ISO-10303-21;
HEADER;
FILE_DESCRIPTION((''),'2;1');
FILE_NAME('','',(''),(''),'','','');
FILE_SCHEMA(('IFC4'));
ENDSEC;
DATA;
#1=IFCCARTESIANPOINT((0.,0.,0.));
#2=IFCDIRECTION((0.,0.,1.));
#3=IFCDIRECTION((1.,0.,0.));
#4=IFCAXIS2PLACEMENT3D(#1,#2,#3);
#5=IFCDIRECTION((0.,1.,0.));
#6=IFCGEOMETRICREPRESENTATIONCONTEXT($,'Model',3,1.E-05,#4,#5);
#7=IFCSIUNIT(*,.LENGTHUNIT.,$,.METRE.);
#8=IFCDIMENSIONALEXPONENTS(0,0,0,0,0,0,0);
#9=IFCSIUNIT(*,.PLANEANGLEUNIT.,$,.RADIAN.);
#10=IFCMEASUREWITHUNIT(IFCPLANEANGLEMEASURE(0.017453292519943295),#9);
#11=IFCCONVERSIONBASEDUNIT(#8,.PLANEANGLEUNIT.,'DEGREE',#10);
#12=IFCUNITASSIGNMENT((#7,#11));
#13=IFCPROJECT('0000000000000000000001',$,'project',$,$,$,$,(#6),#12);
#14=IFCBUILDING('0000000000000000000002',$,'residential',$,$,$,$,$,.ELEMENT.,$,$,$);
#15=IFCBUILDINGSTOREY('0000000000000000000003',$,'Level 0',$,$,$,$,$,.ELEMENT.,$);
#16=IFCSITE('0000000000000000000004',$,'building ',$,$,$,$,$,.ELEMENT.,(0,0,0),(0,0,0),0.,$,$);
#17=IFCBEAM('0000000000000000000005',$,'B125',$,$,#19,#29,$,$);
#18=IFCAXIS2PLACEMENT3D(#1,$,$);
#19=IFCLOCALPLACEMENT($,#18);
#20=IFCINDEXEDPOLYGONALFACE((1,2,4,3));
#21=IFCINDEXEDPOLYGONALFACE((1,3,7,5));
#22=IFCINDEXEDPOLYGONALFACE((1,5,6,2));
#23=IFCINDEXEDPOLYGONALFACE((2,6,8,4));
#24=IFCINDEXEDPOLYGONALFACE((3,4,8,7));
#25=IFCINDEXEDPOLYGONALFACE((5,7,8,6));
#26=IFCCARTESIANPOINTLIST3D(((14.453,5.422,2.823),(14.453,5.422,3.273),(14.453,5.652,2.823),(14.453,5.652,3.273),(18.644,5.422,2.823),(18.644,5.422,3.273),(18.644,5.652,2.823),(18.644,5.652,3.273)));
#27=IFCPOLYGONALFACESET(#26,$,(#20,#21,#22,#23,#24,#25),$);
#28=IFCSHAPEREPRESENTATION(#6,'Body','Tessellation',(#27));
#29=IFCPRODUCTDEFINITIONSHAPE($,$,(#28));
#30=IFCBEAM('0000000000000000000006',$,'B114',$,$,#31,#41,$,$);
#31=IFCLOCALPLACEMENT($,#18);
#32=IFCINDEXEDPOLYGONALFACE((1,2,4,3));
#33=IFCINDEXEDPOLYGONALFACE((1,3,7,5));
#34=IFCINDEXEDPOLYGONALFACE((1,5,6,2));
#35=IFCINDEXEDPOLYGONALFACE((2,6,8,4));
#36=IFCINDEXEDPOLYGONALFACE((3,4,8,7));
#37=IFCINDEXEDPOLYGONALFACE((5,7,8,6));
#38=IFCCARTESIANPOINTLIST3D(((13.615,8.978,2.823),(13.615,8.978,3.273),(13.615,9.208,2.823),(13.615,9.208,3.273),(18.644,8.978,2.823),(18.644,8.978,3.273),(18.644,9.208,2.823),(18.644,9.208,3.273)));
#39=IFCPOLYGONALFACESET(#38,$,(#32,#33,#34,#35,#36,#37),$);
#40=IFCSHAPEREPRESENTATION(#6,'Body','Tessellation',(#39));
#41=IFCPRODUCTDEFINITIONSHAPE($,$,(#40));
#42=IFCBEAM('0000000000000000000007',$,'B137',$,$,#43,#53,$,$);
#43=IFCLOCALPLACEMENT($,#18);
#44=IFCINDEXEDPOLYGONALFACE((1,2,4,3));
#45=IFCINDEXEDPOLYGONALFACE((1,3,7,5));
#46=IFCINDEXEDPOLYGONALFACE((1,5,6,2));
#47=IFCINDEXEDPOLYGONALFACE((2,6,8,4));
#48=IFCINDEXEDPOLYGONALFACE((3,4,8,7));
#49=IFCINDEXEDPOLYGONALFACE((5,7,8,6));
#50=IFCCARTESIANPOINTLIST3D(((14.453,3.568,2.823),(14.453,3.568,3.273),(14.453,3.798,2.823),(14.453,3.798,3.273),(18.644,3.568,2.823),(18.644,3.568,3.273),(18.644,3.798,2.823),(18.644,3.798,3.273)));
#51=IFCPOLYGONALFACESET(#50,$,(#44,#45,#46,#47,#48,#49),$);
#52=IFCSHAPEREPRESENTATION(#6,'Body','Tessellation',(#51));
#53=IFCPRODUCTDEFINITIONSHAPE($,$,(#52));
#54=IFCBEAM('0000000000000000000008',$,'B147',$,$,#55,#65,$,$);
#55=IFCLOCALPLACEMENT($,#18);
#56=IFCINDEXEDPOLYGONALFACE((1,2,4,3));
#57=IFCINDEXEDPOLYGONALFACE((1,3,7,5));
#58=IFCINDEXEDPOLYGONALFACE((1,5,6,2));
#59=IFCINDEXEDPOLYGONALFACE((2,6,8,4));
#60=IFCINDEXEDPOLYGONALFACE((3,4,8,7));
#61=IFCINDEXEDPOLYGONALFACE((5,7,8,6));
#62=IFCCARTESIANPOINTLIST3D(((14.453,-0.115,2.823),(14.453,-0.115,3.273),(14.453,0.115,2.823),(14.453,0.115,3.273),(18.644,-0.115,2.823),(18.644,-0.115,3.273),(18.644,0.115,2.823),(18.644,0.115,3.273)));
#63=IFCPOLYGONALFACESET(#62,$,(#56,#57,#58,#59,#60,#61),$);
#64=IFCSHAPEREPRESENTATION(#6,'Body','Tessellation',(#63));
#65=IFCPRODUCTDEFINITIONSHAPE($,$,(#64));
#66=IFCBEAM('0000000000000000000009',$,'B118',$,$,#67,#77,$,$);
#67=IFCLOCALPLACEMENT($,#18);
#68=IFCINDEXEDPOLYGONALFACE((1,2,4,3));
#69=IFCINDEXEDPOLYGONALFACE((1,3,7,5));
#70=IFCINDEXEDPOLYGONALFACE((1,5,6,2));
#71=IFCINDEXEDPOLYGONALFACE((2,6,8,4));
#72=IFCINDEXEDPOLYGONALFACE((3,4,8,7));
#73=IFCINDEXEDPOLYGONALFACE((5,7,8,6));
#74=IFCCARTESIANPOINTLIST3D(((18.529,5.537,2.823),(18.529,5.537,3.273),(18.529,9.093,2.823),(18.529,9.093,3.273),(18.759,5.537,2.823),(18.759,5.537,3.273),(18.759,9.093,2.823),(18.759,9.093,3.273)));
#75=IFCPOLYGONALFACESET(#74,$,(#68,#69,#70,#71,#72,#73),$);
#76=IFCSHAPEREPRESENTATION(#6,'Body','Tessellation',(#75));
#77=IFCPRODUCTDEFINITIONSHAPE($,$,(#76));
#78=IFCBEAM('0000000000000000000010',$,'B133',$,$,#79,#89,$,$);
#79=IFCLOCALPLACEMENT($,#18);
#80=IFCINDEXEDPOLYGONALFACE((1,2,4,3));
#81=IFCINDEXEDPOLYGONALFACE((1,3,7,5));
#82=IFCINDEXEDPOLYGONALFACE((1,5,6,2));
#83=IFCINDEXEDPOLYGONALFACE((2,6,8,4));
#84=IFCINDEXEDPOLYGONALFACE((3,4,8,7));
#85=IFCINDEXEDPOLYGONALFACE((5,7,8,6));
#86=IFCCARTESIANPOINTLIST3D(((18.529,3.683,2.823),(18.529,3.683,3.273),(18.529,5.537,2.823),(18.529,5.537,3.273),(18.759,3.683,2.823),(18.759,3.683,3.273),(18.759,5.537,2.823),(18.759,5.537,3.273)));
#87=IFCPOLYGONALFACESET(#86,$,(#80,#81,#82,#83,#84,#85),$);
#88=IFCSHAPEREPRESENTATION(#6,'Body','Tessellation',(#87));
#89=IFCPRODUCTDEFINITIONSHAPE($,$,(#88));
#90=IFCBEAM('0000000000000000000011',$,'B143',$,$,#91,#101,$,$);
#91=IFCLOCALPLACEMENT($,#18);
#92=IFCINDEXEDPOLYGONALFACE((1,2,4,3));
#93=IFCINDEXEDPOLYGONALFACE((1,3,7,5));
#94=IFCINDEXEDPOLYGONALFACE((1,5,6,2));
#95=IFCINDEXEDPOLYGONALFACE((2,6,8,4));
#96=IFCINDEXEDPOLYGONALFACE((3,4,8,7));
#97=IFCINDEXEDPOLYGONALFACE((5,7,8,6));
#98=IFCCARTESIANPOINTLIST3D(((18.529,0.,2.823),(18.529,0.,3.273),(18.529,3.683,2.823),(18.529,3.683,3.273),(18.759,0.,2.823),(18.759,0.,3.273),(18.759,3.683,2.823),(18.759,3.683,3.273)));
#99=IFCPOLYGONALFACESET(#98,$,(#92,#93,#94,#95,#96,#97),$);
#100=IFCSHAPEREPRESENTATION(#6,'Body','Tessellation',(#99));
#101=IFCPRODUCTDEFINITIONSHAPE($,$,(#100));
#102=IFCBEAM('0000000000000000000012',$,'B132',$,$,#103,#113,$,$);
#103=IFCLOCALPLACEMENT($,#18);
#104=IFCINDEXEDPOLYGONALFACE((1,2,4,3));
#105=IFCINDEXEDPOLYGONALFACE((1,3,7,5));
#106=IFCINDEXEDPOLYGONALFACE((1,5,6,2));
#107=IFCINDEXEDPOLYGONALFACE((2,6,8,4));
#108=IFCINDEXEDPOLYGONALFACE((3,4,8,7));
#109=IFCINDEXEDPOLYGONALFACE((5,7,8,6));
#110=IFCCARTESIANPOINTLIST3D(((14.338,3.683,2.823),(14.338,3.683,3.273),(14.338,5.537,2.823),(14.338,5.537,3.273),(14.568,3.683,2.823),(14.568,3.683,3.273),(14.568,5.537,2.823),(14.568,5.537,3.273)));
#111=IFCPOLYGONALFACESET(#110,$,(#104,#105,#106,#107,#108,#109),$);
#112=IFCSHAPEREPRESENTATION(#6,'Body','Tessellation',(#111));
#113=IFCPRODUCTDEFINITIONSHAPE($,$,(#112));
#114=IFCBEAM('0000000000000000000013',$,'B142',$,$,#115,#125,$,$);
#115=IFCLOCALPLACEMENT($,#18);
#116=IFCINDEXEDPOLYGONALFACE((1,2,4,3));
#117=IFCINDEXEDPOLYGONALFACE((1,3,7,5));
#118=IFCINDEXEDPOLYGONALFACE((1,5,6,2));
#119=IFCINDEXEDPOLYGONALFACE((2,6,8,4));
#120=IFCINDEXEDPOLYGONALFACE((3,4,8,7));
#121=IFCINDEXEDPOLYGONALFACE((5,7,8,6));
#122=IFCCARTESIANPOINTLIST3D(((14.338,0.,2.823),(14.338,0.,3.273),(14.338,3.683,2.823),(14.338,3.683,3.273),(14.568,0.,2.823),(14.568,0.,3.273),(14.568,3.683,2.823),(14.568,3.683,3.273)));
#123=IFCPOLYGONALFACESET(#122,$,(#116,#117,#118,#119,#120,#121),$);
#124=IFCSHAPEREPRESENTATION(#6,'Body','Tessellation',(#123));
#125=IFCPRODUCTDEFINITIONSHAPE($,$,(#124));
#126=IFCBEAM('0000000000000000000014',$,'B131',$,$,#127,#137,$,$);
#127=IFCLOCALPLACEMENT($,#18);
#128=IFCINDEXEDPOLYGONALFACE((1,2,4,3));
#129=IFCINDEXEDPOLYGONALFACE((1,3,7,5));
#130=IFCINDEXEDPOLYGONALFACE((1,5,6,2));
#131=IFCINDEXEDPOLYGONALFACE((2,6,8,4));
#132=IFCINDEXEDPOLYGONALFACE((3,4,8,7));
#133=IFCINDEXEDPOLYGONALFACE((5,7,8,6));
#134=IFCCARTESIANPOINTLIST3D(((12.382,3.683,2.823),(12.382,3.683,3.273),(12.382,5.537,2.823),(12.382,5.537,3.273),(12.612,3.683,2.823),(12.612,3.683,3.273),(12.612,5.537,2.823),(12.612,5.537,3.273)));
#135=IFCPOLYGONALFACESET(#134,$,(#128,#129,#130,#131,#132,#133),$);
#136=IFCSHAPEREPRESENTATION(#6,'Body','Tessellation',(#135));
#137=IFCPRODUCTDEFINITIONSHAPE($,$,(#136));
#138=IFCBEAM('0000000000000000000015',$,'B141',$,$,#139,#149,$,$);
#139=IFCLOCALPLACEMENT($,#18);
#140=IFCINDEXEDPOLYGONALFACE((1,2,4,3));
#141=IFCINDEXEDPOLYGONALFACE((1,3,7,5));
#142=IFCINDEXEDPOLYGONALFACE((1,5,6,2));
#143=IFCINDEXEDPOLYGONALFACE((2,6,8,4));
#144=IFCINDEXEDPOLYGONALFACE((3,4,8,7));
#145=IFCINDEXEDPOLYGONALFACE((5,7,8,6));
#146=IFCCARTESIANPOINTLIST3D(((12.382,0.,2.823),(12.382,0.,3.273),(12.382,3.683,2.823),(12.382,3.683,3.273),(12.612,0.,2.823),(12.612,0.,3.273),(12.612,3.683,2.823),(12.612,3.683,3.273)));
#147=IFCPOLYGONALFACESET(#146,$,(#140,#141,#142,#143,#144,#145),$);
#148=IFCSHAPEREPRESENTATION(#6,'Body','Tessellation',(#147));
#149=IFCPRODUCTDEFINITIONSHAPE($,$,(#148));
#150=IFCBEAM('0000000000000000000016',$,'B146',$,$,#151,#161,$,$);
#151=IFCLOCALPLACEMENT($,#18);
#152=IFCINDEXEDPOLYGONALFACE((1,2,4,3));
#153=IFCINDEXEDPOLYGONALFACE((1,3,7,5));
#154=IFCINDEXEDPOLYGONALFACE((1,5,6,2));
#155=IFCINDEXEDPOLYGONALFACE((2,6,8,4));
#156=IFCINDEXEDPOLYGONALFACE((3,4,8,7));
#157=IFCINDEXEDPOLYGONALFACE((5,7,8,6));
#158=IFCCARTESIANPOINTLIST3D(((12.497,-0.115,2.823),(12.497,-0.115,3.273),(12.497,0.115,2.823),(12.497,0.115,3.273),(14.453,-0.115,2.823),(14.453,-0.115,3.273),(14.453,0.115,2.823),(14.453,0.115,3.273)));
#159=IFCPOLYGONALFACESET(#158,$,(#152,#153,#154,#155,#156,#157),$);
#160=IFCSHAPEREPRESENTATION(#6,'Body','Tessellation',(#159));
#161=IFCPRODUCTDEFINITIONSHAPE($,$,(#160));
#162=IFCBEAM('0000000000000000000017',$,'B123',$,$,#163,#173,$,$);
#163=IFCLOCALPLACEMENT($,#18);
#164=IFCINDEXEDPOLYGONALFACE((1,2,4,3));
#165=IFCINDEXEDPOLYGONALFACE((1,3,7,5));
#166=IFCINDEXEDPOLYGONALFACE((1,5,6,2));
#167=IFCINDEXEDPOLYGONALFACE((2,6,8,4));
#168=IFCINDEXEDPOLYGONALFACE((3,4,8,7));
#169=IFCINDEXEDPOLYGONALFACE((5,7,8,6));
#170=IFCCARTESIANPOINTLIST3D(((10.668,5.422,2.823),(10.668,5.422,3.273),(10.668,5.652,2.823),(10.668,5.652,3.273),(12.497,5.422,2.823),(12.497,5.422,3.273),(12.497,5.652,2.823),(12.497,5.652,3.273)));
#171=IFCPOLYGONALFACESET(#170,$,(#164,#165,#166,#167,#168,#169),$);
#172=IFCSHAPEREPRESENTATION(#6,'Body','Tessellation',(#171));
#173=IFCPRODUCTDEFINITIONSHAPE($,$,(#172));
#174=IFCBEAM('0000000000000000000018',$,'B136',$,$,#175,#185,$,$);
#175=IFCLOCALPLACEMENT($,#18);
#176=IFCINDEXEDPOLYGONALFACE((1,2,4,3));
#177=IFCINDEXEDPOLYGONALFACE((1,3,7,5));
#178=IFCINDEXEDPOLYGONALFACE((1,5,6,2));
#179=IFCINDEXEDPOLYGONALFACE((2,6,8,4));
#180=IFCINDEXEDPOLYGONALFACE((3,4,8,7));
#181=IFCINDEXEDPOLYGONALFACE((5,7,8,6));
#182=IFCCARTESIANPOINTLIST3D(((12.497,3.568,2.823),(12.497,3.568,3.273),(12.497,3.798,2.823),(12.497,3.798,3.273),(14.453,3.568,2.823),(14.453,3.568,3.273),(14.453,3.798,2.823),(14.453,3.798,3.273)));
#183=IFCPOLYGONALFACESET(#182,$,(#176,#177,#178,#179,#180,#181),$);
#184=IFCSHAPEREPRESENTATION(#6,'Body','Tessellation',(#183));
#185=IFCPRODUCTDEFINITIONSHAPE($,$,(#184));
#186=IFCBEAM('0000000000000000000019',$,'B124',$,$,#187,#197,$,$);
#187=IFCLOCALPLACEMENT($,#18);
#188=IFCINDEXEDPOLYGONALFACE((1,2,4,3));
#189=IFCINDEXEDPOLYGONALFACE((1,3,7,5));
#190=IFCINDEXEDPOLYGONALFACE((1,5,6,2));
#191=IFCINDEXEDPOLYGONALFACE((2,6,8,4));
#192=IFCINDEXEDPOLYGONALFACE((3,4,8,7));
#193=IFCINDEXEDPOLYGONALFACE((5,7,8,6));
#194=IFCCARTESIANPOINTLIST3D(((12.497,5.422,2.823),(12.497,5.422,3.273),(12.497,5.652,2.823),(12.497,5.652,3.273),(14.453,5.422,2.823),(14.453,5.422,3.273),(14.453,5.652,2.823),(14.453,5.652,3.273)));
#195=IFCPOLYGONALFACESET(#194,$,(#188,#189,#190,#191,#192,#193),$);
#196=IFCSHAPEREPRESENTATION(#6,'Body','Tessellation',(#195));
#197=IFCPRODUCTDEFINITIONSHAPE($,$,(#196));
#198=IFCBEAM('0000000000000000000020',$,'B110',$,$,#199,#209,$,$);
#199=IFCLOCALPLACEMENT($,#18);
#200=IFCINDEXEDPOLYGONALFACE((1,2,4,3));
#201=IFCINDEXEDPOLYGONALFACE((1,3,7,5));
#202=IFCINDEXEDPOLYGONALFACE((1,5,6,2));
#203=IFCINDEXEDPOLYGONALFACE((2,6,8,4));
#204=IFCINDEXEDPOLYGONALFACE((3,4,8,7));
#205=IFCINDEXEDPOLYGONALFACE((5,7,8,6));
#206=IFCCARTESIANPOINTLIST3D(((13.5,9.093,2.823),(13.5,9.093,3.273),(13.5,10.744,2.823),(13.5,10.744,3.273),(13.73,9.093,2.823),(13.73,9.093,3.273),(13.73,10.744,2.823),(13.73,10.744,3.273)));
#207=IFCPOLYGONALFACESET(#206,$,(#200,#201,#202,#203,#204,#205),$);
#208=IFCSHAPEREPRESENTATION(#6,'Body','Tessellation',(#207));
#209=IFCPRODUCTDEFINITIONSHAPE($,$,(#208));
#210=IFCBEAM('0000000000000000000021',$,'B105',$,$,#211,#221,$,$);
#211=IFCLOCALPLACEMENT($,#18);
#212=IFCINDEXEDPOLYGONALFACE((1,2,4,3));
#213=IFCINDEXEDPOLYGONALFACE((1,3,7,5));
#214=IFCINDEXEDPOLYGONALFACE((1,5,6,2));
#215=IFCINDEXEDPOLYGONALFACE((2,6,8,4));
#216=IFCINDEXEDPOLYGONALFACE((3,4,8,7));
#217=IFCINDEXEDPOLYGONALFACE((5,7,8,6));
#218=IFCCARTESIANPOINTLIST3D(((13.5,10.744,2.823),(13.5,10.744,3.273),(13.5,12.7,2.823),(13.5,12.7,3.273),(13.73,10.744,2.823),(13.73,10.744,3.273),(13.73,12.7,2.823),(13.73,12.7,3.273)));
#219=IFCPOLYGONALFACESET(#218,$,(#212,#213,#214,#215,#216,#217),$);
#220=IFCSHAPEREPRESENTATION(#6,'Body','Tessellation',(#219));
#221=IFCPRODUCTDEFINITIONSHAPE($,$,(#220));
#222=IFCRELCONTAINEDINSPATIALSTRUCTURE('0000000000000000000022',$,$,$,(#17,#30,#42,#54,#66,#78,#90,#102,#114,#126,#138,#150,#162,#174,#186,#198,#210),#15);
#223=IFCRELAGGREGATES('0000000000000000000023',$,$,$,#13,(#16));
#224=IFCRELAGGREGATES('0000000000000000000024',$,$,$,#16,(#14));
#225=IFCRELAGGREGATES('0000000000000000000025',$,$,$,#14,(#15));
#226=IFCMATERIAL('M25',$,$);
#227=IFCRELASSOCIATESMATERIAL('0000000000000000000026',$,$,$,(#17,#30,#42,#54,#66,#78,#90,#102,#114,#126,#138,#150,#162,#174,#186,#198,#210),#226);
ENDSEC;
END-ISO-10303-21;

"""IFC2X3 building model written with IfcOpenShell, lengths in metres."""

from ifc_helpers import new_model, entity, si_unit, converted_unit, direction, frame, frame_2d, origin_with_axes, place, context, project, spatial, rectangle, extrude, material, element, save


model = new_model("IFC2X3")

# Units and contexts
model_context = context("Model", 3, precision=1e-05, world=origin_with_axes(), true_north=direction((0.0, 1.0, 0.0)))
ifc_project = project(units=[si_unit("LENGTHUNIT", "METRE"), converted_unit("PLANEANGLEUNIT", "DEGREE", entity("IfcPlaneAngleMeasure", 0.017453292519943295), si_unit("PLANEANGLEUNIT", "RADIAN"), dimensions=[0, 0, 0, 0, 0, 0, 0])], contexts=[model_context])

# Site, building, storey
site = spatial("IfcSite", under=ifc_project, Name="building ", CompositionType="ELEMENT", RefLatitude=(0, 0, 0), RefLongitude=(0, 0, 0), RefElevation=0.0)
building = spatial("IfcBuilding", under=site, Name="residential", CompositionType="ELEMENT")
storey = spatial("IfcBuildingStorey", under=building, Name="Level 0", CompositionType="ELEMENT")

# Beams
ifc_material = material(Name="M25")
placement = place(None, origin_with_axes())
element("IfcBeam", 1, at=placement, inside=storey, material=ifc_material, Name="B125", context=model_context, shape_type="SweptSolid", body=[
    extrude(rectangle(XDim=0.23, YDim=0.45, at=frame_2d((0.0, 0.0), x_axis=(0.0, 1.0, 0.0))), frame((18.644, 5.537, 3.048), z_axis=(-1.0, 0.0, 0.0), x_axis=(0.0, 0.0, -1.0)), (0.0, 0.0, 1.0), 4.191),
])
element("IfcBeam", 2, at=placement, inside=storey, material=ifc_material, Name="B114", context=model_context, shape_type="SweptSolid", body=[
    extrude(rectangle(XDim=0.23, YDim=0.45, at=frame_2d((0.0, 0.0), x_axis=(0.0, 1.0, 0.0))), frame((18.644, 9.093, 3.048), z_axis=(-1.0, 0.0, 0.0), x_axis=(0.0, 0.0, -1.0)), (0.0, 0.0, 1.0), 5.029),
])
element("IfcBeam", 3, at=placement, inside=storey, material=ifc_material, Name="B137", context=model_context, shape_type="SweptSolid", body=[
    extrude(rectangle(XDim=0.23, YDim=0.45, at=frame_2d((0.0, 0.0), x_axis=(0.0, 1.0, 0.0))), frame((18.644, 3.683, 3.048), z_axis=(-1.0, 0.0, 0.0), x_axis=(0.0, 0.0, -1.0)), (0.0, 0.0, 1.0), 4.191),
])
element("IfcBeam", 4, at=placement, inside=storey, material=ifc_material, Name="B147", context=model_context, shape_type="SweptSolid", body=[
    extrude(rectangle(XDim=0.23, YDim=0.45, at=frame_2d((0.0, 0.0), x_axis=(0.0, 1.0, 0.0))), frame((18.644, 0.0, 3.048), z_axis=(-1.0, 0.0, 0.0), x_axis=(0.0, 0.0, -1.0)), (0.0, 0.0, 1.0), 4.191),
])
element("IfcBeam", 5, at=placement, inside=storey, material=ifc_material, Name="B118", context=model_context, shape_type="SweptSolid", body=[
    extrude(rectangle(XDim=0.23, YDim=0.45, at=frame_2d((0.0, 0.0), x_axis=(0.0, 1.0, 0.0))), frame((18.644, 9.093, 3.048), z_axis=(0.0, -1.0, 0.0), x_axis=(0.0, 0.0, -1.0)), (0.0, 0.0, 1.0), 3.556),
])
element("IfcBeam", 6, at=placement, inside=storey, material=ifc_material, Name="B133", context=model_context, shape_type="SweptSolid", body=[
    extrude(rectangle(XDim=0.23, YDim=0.45, at=frame_2d((0.0, 0.0), x_axis=(0.0, 1.0, 0.0))), frame((18.644, 3.683, 3.048), z_axis=(0.0, 1.0, 0.0), x_axis=(0.0, 0.0, -1.0)), (0.0, 0.0, 1.0), 1.854),
])
element("IfcBeam", 7, at=placement, inside=storey, material=ifc_material, Name="B143", context=model_context, shape_type="SweptSolid", body=[
    extrude(rectangle(XDim=0.23, YDim=0.45, at=frame_2d((0.0, 0.0), x_axis=(0.0, 1.0, 0.0))), frame((18.644, 0.0, 3.048), z_axis=(0.0, 1.0, 0.0), x_axis=(0.0, 0.0, -1.0)), (0.0, 0.0, 1.0), 3.683),
])
element("IfcBeam", 8, at=placement, inside=storey, material=ifc_material, Name="B132", context=model_context, shape_type="SweptSolid", body=[
    extrude(rectangle(XDim=0.23, YDim=0.45, at=frame_2d((0.0, 0.0), x_axis=(0.0, 1.0, 0.0))), frame((14.453, 3.683, 3.048), z_axis=(0.0, 1.0, 0.0), x_axis=(0.0, 0.0, -1.0)), (0.0, 0.0, 1.0), 1.854),
])
element("IfcBeam", 9, at=placement, inside=storey, material=ifc_material, Name="B142", context=model_context, shape_type="SweptSolid", body=[
    extrude(rectangle(XDim=0.23, YDim=0.45, at=frame_2d((0.0, 0.0), x_axis=(0.0, 1.0, 0.0))), frame((14.453, 0.0, 3.048), z_axis=(0.0, 1.0, 0.0), x_axis=(0.0, 0.0, -1.0)), (0.0, 0.0, 1.0), 3.683),
])
element("IfcBeam", 10, at=placement, inside=storey, material=ifc_material, Name="B131", context=model_context, shape_type="SweptSolid", body=[
    extrude(rectangle(XDim=0.23, YDim=0.45, at=frame_2d((0.0, 0.0), x_axis=(0.0, 1.0, 0.0))), frame((12.497, 3.683, 3.048), z_axis=(0.0, 1.0, 0.0), x_axis=(0.0, 0.0, -1.0)), (0.0, 0.0, 1.0), 1.854),
])
element("IfcBeam", 11, at=placement, inside=storey, material=ifc_material, Name="B141", context=model_context, shape_type="SweptSolid", body=[
    extrude(rectangle(XDim=0.23, YDim=0.45, at=frame_2d((0.0, 0.0), x_axis=(0.0, 1.0, 0.0))), frame((12.497, 0.0, 3.048), z_axis=(0.0, 1.0, 0.0), x_axis=(0.0, 0.0, -1.0)), (0.0, 0.0, 1.0), 3.683),
])
element("IfcBeam", 12, at=placement, inside=storey, material=ifc_material, Name="B146", context=model_context, shape_type="SweptSolid", body=[
    extrude(rectangle(XDim=0.23, YDim=0.45, at=frame_2d((0.0, 0.0), x_axis=(0.0, 1.0, 0.0))), frame((12.497, 0.0, 3.048), z_axis=(1.0, 0.0, 0.0), x_axis=(0.0, 0.0, -1.0)), (0.0, 0.0, 1.0), 1.956),
])
element("IfcBeam", 13, at=placement, inside=storey, material=ifc_material, Name="B123", context=model_context, shape_type="SweptSolid", body=[
    extrude(rectangle(XDim=0.23, YDim=0.45, at=frame_2d((0.0, 0.0), x_axis=(0.0, 1.0, 0.0))), frame((10.668, 5.537, 3.048), z_axis=(1.0, 0.0, 0.0), x_axis=(0.0, 0.0, -1.0)), (0.0, 0.0, 1.0), 1.829),
])
element("IfcBeam", 14, at=placement, inside=storey, material=ifc_material, Name="B136", context=model_context, shape_type="SweptSolid", body=[
    extrude(rectangle(XDim=0.23, YDim=0.45, at=frame_2d((0.0, 0.0), x_axis=(0.0, 1.0, 0.0))), frame((12.497, 3.683, 3.048), z_axis=(1.0, 0.0, 0.0), x_axis=(0.0, 0.0, -1.0)), (0.0, 0.0, 1.0), 1.956),
])
element("IfcBeam", 15, at=placement, inside=storey, material=ifc_material, Name="B124", context=model_context, shape_type="SweptSolid", body=[
    extrude(rectangle(XDim=0.23, YDim=0.45, at=frame_2d((0.0, 0.0), x_axis=(0.0, 1.0, 0.0))), frame((12.497, 5.537, 3.048), z_axis=(1.0, 0.0, 0.0), x_axis=(0.0, 0.0, -1.0)), (0.0, 0.0, 1.0), 1.956),
])
element("IfcBeam", 16, at=placement, inside=storey, material=ifc_material, Name="B110", context=model_context, shape_type="SweptSolid", body=[
    extrude(rectangle(XDim=0.23, YDim=0.45, at=frame_2d((0.0, 0.0), x_axis=(0.0, 1.0, 0.0))), frame((13.615, 9.093, 3.048), z_axis=(0.0, 1.0, 0.0), x_axis=(0.0, 0.0, -1.0)), (0.0, 0.0, 1.0), 1.651),
])
element("IfcBeam", 17, at=placement, inside=storey, material=ifc_material, Name="B105", context=model_context, shape_type="SweptSolid", body=[
    extrude(rectangle(XDim=0.23, YDim=0.45, at=frame_2d((0.0, 0.0), x_axis=(0.0, 1.0, 0.0))), frame((13.615, 10.744, 3.048), z_axis=(0.0, 1.0, 0.0), x_axis=(0.0, 0.0, -1.0)), (0.0, 0.0, 1.0), 1.956),
])

save(model, "model.ifc")
